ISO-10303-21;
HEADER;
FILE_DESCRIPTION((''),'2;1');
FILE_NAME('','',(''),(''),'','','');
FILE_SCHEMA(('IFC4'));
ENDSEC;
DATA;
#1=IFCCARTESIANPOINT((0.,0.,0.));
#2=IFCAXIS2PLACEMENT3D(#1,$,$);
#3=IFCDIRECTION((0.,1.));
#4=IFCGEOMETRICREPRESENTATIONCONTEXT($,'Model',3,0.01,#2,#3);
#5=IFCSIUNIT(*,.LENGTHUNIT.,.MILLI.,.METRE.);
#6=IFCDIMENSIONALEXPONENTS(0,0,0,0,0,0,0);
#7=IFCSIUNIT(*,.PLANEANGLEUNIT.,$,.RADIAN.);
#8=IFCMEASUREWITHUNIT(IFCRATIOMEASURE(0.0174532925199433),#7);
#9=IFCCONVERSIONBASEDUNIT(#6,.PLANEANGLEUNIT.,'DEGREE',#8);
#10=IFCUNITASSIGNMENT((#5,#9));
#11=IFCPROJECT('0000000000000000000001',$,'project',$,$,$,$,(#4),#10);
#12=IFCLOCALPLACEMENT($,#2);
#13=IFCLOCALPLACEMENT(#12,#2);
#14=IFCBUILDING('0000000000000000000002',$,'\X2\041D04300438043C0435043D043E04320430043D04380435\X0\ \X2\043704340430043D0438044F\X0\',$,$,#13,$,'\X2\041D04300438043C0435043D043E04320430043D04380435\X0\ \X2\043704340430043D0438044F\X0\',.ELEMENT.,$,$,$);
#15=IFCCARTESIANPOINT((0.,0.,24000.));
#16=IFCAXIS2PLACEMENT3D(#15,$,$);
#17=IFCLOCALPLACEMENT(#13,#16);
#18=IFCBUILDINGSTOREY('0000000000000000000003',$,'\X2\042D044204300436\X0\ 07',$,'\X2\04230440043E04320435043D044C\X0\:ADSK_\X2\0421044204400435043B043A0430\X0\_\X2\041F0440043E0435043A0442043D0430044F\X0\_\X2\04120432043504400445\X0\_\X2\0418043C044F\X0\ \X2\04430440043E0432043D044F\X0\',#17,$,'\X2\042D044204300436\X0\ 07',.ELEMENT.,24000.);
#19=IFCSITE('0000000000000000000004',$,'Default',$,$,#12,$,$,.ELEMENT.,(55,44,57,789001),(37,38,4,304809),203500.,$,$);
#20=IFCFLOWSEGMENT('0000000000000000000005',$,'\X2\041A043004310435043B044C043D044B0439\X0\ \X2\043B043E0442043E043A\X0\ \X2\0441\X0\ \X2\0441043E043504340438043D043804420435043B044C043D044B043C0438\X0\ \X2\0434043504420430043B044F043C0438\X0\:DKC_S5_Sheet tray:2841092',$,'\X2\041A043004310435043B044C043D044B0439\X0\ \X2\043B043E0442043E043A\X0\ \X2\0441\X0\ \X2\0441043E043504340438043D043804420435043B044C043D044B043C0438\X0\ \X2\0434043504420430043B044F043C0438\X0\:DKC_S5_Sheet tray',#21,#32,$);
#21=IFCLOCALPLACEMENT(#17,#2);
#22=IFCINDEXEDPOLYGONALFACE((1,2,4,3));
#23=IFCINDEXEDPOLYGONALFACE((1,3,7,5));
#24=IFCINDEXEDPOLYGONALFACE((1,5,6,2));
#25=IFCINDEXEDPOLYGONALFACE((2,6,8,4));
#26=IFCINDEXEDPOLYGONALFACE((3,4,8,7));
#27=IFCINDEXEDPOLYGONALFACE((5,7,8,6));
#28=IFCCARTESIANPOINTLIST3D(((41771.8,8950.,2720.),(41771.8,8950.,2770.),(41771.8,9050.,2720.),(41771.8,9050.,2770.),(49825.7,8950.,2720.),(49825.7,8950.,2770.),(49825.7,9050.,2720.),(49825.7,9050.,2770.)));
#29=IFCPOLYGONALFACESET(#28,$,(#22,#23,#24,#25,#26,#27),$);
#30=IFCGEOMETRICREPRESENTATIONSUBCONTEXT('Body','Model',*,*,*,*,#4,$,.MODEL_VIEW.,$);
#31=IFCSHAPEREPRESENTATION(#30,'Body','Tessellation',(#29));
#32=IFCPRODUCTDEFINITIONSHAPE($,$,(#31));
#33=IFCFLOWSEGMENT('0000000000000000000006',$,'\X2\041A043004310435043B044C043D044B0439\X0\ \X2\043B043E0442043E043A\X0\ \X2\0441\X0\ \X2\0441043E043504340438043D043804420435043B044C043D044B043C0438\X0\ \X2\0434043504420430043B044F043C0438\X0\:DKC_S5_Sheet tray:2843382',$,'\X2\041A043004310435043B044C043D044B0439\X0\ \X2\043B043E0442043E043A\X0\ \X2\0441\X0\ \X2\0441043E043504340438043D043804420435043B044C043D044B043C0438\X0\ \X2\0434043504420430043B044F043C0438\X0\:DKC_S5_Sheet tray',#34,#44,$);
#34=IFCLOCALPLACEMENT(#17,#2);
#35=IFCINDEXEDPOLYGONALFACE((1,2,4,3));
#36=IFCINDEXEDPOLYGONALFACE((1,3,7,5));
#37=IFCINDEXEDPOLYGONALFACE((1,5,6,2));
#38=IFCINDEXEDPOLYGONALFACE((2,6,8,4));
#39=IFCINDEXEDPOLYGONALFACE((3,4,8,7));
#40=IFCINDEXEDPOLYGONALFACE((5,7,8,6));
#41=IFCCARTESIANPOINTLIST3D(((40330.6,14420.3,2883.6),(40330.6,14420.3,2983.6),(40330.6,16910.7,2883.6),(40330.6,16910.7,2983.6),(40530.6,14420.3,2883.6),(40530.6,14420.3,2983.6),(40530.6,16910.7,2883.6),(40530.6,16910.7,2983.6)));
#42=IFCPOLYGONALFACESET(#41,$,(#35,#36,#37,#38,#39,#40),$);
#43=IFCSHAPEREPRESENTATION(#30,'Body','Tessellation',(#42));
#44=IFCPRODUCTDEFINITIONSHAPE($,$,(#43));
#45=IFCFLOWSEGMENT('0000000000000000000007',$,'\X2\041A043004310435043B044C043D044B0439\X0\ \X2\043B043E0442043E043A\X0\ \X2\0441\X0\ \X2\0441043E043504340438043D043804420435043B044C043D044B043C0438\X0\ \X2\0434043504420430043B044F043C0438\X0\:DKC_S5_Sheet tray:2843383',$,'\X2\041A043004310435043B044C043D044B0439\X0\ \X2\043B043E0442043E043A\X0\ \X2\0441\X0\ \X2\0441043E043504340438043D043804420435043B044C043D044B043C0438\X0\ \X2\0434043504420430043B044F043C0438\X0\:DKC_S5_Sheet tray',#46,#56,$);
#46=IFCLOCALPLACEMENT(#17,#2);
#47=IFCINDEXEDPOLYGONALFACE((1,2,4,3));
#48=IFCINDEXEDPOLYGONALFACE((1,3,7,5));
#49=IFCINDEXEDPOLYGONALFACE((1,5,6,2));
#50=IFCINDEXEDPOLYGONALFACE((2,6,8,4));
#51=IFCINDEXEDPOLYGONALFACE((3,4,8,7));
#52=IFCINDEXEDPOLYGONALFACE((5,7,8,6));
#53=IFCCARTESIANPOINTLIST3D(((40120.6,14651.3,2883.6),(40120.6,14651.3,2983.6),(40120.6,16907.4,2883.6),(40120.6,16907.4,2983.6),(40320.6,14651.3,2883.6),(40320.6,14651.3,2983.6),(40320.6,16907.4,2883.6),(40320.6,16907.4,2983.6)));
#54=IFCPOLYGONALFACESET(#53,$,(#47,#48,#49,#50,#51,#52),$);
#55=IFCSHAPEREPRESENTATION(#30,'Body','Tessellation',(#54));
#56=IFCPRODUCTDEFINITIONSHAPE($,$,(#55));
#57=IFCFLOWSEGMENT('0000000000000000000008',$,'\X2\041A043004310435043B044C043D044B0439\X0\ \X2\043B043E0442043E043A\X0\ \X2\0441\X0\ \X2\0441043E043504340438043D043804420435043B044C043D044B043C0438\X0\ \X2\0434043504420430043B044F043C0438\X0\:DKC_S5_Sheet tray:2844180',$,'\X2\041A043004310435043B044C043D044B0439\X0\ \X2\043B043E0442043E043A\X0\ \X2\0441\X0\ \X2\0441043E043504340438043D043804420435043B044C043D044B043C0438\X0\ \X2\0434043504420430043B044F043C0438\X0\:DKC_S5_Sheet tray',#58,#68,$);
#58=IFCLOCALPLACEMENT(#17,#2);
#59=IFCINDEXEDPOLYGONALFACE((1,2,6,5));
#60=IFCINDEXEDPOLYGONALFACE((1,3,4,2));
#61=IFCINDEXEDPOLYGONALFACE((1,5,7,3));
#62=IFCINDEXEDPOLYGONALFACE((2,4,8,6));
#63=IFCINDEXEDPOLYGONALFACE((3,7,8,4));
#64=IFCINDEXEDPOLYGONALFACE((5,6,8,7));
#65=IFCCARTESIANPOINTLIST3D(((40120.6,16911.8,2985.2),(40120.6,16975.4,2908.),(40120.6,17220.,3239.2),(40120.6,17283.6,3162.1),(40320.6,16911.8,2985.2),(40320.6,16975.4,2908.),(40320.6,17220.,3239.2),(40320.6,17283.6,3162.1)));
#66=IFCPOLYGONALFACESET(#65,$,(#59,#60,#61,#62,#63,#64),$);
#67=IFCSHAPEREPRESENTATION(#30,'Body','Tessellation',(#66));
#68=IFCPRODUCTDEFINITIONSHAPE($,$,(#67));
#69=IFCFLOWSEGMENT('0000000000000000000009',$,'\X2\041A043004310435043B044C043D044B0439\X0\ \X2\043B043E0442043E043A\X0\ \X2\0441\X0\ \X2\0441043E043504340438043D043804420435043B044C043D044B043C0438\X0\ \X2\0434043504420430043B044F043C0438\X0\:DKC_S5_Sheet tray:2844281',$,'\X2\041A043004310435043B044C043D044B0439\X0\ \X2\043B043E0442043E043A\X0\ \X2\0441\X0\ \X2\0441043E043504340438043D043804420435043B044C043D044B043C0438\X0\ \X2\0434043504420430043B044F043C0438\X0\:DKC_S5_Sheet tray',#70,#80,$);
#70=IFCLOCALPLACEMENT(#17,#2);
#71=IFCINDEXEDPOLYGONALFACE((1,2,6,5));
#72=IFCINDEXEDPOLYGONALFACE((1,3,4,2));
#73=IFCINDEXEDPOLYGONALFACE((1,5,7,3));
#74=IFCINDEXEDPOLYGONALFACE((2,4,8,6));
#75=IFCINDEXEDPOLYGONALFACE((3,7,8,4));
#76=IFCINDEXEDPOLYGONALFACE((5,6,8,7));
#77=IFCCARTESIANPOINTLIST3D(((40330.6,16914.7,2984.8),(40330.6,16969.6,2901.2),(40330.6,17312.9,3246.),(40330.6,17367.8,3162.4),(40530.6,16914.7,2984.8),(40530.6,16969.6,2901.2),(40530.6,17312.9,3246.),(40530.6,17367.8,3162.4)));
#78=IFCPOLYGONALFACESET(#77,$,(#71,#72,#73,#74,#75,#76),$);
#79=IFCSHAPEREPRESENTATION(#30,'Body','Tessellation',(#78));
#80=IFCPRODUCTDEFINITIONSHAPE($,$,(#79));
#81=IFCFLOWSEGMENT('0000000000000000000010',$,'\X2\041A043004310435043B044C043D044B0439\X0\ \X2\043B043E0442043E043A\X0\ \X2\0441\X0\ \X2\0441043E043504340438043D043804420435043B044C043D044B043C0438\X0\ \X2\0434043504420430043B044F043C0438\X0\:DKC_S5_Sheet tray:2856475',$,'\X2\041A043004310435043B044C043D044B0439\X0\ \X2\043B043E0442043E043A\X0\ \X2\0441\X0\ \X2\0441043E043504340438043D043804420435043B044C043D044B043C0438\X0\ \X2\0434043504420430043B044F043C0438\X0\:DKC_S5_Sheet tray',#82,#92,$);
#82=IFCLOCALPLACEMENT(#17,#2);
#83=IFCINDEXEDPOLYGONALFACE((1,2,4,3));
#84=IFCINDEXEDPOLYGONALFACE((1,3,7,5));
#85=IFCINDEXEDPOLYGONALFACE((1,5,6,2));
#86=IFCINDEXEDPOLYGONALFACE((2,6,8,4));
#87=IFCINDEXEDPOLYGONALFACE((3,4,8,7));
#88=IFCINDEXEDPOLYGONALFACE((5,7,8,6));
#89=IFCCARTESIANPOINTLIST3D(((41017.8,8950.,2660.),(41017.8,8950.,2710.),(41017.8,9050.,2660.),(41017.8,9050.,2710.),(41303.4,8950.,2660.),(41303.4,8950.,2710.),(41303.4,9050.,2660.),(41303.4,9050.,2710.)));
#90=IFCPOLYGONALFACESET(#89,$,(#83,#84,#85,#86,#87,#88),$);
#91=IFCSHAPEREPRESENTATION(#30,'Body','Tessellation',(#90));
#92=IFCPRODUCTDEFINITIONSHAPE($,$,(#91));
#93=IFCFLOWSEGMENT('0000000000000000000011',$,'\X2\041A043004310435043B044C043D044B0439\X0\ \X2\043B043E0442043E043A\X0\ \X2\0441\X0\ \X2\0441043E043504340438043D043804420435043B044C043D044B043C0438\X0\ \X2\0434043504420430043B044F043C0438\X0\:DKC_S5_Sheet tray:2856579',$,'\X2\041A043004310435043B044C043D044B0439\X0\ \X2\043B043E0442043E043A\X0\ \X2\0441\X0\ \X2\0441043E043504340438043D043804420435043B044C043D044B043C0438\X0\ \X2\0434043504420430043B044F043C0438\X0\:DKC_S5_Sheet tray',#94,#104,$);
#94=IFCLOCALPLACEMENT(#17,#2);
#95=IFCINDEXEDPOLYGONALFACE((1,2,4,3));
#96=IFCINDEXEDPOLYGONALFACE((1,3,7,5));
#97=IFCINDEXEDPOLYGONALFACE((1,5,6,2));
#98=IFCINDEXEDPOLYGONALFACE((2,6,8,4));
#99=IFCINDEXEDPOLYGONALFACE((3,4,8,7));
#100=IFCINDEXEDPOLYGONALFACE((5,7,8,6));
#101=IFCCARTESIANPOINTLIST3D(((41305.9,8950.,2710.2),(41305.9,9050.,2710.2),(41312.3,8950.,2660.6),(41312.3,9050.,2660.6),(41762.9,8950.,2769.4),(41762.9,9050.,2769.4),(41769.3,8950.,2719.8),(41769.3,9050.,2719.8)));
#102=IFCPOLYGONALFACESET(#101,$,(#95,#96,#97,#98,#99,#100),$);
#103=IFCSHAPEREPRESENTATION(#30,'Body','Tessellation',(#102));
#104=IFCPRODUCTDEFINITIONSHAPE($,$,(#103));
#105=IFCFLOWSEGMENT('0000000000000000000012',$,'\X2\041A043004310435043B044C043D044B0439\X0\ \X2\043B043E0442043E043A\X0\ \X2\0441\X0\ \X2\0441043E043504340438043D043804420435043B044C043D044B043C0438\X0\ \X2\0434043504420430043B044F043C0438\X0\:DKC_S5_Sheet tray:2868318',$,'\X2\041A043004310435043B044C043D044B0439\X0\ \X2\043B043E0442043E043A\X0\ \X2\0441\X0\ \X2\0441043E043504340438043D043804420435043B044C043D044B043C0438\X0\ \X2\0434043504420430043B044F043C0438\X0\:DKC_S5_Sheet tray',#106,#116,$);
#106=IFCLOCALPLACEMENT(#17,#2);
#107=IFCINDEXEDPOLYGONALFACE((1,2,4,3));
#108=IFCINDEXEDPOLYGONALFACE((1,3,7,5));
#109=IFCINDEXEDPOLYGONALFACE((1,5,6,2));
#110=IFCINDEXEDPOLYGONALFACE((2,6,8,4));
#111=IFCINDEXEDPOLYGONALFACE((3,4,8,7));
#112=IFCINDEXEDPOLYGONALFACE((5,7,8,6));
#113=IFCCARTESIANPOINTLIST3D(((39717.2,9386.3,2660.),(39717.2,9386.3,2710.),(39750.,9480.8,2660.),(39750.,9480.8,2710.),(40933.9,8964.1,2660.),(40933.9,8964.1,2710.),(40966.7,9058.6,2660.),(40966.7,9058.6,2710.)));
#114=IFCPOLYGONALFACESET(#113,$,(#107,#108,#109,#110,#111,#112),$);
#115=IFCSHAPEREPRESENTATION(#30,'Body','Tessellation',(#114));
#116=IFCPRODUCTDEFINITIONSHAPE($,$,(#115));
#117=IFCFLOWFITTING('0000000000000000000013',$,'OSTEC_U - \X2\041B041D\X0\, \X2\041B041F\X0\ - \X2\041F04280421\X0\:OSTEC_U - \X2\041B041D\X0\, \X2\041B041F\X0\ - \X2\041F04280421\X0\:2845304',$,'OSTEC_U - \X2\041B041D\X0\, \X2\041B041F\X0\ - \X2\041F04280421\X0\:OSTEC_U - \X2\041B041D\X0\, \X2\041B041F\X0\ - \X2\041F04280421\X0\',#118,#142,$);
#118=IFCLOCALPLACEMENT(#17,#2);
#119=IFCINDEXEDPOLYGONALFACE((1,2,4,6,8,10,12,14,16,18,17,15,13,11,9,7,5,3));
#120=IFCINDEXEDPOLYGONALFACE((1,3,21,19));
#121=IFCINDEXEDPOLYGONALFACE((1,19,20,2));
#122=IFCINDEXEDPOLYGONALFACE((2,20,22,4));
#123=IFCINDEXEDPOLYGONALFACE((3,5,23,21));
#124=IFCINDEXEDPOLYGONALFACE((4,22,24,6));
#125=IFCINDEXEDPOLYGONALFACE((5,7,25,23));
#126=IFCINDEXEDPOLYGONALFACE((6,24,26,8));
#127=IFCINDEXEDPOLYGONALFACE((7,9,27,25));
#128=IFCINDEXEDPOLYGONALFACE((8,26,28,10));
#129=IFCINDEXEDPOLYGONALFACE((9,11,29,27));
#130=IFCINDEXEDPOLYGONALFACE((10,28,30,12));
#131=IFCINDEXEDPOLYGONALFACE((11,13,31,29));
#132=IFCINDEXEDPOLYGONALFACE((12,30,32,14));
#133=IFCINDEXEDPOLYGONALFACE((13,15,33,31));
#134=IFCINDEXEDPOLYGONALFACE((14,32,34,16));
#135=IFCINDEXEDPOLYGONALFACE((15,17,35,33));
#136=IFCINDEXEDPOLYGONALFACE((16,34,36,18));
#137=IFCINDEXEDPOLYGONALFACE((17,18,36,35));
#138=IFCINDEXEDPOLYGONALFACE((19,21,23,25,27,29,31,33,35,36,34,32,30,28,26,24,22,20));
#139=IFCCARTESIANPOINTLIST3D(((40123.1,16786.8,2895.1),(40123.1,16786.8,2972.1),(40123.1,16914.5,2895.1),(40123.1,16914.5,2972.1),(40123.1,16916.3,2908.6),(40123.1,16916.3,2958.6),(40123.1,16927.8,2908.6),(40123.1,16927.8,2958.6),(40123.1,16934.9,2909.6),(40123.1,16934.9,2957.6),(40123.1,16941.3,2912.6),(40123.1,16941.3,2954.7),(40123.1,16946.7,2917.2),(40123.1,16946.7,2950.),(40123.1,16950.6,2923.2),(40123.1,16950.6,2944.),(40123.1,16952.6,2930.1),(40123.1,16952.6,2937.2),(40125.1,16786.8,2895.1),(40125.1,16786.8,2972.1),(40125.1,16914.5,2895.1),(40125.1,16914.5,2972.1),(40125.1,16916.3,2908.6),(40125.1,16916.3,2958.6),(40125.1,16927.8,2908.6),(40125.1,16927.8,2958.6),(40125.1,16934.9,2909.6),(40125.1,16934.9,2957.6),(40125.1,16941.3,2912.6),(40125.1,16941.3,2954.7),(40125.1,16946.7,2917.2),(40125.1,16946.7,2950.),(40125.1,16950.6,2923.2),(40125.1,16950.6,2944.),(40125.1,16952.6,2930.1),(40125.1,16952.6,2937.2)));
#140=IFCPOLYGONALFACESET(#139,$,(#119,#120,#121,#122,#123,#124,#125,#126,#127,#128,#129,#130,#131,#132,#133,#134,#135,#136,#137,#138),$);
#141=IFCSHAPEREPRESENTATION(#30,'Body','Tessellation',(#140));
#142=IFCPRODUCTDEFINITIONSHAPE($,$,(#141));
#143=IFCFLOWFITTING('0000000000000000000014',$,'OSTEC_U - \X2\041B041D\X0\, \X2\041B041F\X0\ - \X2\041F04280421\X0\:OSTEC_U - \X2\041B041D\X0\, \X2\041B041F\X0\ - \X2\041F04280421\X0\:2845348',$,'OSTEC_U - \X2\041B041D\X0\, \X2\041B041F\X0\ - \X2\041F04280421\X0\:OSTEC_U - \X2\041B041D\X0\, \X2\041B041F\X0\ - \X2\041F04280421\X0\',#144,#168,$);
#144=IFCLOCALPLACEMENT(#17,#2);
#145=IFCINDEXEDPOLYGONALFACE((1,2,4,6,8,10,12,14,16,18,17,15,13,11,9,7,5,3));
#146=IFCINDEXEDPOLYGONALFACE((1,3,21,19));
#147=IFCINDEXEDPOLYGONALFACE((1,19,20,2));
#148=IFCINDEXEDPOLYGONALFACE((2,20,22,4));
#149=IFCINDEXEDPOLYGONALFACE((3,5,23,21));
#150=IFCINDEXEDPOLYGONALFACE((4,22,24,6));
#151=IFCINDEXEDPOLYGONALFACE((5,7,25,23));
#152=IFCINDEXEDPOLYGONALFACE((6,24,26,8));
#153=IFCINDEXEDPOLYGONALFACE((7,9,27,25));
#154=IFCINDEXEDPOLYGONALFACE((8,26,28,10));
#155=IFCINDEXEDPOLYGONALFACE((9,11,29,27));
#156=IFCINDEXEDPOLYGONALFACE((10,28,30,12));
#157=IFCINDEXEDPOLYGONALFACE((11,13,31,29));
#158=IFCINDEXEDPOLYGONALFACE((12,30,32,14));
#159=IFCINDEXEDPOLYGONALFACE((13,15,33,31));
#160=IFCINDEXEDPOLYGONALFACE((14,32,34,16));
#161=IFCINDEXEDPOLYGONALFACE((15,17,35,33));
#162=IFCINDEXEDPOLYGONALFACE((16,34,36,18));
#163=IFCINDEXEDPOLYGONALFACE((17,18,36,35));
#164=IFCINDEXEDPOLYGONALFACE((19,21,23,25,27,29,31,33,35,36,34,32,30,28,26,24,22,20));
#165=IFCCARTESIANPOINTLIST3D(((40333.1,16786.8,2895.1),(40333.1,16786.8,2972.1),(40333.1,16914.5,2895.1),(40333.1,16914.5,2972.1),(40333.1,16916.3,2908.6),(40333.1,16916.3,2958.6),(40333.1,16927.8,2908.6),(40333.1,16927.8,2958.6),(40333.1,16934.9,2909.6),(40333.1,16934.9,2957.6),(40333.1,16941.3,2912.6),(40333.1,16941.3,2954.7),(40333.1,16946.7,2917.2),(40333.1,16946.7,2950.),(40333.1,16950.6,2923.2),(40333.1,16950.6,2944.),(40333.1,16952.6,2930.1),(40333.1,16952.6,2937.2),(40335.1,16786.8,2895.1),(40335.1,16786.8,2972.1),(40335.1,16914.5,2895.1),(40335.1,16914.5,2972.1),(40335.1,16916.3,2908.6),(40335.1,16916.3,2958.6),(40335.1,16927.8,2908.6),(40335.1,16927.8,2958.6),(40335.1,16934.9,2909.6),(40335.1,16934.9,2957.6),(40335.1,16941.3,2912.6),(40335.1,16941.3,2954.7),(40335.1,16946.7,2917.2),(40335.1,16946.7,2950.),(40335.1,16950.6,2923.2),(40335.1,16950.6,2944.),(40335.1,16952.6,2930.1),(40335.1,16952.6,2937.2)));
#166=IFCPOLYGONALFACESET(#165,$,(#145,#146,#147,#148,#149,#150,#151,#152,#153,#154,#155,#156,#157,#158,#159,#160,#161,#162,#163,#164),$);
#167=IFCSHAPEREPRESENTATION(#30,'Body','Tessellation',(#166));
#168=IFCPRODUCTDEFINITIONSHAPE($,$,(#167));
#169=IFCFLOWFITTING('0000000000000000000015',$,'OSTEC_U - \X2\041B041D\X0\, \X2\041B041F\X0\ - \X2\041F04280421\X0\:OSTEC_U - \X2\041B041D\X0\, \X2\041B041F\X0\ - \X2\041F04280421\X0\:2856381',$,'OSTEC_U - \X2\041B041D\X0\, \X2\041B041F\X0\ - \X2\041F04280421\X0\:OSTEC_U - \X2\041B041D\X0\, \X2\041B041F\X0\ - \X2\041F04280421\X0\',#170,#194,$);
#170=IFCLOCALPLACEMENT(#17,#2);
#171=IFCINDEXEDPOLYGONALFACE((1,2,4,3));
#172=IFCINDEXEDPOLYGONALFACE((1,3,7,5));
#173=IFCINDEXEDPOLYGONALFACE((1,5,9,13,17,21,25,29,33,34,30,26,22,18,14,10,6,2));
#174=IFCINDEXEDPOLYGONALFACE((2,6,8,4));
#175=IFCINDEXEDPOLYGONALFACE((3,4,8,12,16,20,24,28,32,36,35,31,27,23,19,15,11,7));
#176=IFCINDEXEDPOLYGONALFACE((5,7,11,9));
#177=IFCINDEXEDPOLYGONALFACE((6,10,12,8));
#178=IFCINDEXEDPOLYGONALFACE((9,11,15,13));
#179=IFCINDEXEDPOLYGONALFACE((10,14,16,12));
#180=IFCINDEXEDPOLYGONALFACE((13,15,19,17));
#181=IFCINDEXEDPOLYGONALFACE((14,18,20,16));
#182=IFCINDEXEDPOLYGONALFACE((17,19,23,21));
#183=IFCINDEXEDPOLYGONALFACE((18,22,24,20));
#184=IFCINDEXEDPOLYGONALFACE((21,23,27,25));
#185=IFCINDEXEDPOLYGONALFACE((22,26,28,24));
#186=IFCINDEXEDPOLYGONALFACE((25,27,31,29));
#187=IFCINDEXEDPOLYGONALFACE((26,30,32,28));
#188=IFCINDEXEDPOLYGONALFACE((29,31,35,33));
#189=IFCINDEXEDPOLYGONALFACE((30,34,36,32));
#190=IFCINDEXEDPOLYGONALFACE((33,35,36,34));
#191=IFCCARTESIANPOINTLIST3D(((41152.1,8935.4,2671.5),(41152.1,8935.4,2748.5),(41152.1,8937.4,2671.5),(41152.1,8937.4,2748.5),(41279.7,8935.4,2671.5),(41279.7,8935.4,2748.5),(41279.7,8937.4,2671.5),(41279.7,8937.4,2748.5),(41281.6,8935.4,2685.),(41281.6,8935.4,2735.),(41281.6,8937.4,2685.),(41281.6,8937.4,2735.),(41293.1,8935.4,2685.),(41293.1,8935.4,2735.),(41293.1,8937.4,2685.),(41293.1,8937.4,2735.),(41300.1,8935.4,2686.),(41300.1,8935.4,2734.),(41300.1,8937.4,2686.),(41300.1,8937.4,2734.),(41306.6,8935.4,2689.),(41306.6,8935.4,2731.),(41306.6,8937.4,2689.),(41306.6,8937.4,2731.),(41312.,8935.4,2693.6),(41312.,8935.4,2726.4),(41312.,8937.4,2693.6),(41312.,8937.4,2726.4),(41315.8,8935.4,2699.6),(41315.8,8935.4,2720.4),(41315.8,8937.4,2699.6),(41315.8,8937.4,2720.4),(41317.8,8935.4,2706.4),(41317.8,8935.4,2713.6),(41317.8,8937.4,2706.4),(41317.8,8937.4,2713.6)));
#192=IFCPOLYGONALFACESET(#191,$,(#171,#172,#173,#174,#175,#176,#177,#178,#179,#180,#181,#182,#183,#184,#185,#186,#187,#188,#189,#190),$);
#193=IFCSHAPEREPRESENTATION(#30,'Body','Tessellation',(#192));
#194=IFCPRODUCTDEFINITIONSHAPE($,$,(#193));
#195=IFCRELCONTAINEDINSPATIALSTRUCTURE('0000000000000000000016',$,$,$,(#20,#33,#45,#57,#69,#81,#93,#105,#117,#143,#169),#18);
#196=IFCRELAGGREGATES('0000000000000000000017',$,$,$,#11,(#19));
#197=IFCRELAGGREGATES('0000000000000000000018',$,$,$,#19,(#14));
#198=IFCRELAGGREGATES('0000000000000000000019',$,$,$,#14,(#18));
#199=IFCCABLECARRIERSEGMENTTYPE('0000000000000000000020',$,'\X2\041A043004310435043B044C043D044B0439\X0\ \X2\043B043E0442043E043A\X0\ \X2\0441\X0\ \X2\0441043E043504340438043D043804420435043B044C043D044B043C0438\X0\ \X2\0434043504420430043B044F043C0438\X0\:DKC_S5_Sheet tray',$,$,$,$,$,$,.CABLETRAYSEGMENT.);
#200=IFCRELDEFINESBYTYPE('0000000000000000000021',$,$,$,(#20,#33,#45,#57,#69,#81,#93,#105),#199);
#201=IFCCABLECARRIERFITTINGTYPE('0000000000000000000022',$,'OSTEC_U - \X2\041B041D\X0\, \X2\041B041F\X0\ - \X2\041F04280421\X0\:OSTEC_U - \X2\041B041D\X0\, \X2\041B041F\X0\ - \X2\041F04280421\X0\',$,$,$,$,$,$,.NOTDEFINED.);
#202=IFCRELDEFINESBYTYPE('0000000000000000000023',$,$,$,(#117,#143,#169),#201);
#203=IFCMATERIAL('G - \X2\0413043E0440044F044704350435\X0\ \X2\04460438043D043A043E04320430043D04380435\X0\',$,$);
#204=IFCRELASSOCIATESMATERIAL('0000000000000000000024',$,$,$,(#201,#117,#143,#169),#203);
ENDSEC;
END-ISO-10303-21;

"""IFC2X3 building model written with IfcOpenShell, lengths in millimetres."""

from ifc_helpers import new_model, entity, si_unit, converted_unit, direction, frame, frame_2d, origin, place, context, subcontext, project, spatial, polyline, circle_curve, parameter, trimmed, segment, composite_curve, rectangle, outline, extrude, source, transform, mapped, material, type_object, type_shapes, element, save


model = new_model("IFC2X3")

# Units and contexts
model_context = context("Model", 3, precision=0.01, world=origin(), true_north=direction((0.0, 1.0)))
body_context = subcontext(model_context, "Body", "Model", "MODEL_VIEW")
ifc_project = project(units=[si_unit("LENGTHUNIT", "METRE", prefix="MILLI"), converted_unit("PLANEANGLEUNIT", "DEGREE", entity("IfcRatioMeasure", 0.0174532925199433), si_unit("PLANEANGLEUNIT", "RADIAN"), dimensions=[0, 0, 0, 0, 0, 0, 0])], contexts=[model_context])

# Site, building, storey
site_placement = place(None, frame((0.0, 0.0, 0.0)))
site = spatial("IfcSite", under=ifc_project, at=site_placement, Name="Default", CompositionType="ELEMENT", RefLatitude=(55, 44, 57, 789001), RefLongitude=(37, 38, 4, 304809), RefElevation=203500.0)
building_placement = place(site_placement, origin())
building = spatial("IfcBuilding", under=site, at=building_placement, Name="Наименование здания", LongName="Наименование здания", CompositionType="ELEMENT")
storey_placement = place(building_placement, frame((0.0, 0.0, 24000.0)))
storey = spatial("IfcBuildingStorey", under=building, at=storey_placement, Name="Этаж 07", ObjectType="Уровень:ADSK_Стрелка_Проектная_Вверх_Имя уровня", LongName="Этаж 07", CompositionType="ELEMENT", Elevation=24000.0)

# Flow segments
cable_carrier_segment_type = type_object("IfcCableCarrierSegmentType", Name="Кабельный лоток с соединительными деталями:DKC_S5_Sheet tray", PredefinedType="CABLETRAYSEGMENT")
flow_segment_1_placement = place(storey_placement, frame((41771.8, 8950.0, 2720.0)))
element("IfcFlowSegment", 1, at=flow_segment_1_placement, inside=storey, type_object=cable_carrier_segment_type, Name="Кабельный лоток с соединительными деталями:DKC_S5_Sheet tray:2841092", ObjectType="Кабельный лоток с соединительными деталями:DKC_S5_Sheet tray", context=body_context, shape_type="SweptSolid", body=[
    extrude(rectangle(XDim=8053.8, YDim=100.0, at=frame_2d((0.0, 0.0), x_axis=(1.0, 0.0))), frame((4026.9, 50.0, 0.0), z_axis=(0.0, 0.0, 1.0), x_axis=(-1.0, 0.0, 0.0)), (0.0, 0.0, 1.0), 50.0),
])
flow_segment_2_placement = place(storey_placement, frame((40330.6, 14420.3, 2883.6)))
element("IfcFlowSegment", 2, at=flow_segment_2_placement, inside=storey, type_object=cable_carrier_segment_type, Name="Кабельный лоток с соединительными деталями:DKC_S5_Sheet tray:2843382", ObjectType="Кабельный лоток с соединительными деталями:DKC_S5_Sheet tray", context=body_context, shape_type="SweptSolid", body=[
    extrude(rectangle(XDim=2490.4, YDim=200.0, at=frame_2d((0.0, 0.0), x_axis=(1.0, 0.0))), frame((100.0, 1245.2, 0.0), z_axis=(0.0, 0.0, 1.0), x_axis=(0.0, -1.0, 0.0)), (0.0, 0.0, 1.0), 100.0),
])
flow_segment_3_placement = place(storey_placement, frame((40120.6, 14651.3, 2883.6)))
element("IfcFlowSegment", 3, at=flow_segment_3_placement, inside=storey, type_object=cable_carrier_segment_type, Name="Кабельный лоток с соединительными деталями:DKC_S5_Sheet tray:2843383", ObjectType="Кабельный лоток с соединительными деталями:DKC_S5_Sheet tray", context=body_context, shape_type="SweptSolid", body=[
    extrude(rectangle(XDim=2256.1, YDim=200.0, at=frame_2d((0.0, 0.0), x_axis=(1.0, 0.0))), frame((100.0, 1128.1, 0.0), z_axis=(0.0, 0.0, 1.0), x_axis=(0.0, -1.0, 0.0)), (0.0, 0.0, 1.0), 100.0),
])
flow_segment_4_placement = place(storey_placement, frame((40120.6, 16911.8, 2908.0)))
element("IfcFlowSegment", 4, at=flow_segment_4_placement, inside=storey, type_object=cable_carrier_segment_type, Name="Кабельный лоток с соединительными деталями:DKC_S5_Sheet tray:2844180", ObjectType="Кабельный лоток с соединительными деталями:DKC_S5_Sheet tray", context=body_context, shape_type="SweptSolid", body=[
    extrude(rectangle(XDim=100.0, YDim=399.5, at=frame_2d((0.0, 0.0), x_axis=(0.0, 1.0))), frame((0.0, 185.9, 165.6), z_axis=(1.0, 0.0, 0.0), x_axis=(0.0, 0.771695, 0.635992)), (0.0, 0.0, 1.0), 200.0),
])
flow_segment_5_placement = place(storey_placement, frame((40330.6, 16914.7, 2901.2)))
element("IfcFlowSegment", 5, at=flow_segment_5_placement, inside=storey, type_object=cable_carrier_segment_type, Name="Кабельный лоток с соединительными деталями:DKC_S5_Sheet tray:2844281", ObjectType="Кабельный лоток с соединительными деталями:DKC_S5_Sheet tray", context=body_context, shape_type="SweptSolid", body=[
    extrude(rectangle(XDim=100.0, YDim=476.2, at=frame_2d((0.0, 0.0), x_axis=(0.0, 1.0))), frame((0.0, 226.5, 172.4), z_axis=(1.0, 0.0, 0.0), x_axis=(0.0, 0.836155, 0.548493)), (0.0, 0.0, 1.0), 200.0),
])
flow_segment_6_placement = place(storey_placement, frame((41017.8, 8950.0, 2660.0)))
element("IfcFlowSegment", 6, at=flow_segment_6_placement, inside=storey, type_object=cable_carrier_segment_type, Name="Кабельный лоток с соединительными деталями:DKC_S5_Sheet tray:2856475", ObjectType="Кабельный лоток с соединительными деталями:DKC_S5_Sheet tray", context=body_context, shape_type="SweptSolid", body=[
    extrude(rectangle(XDim=285.6, YDim=100.0, at=frame_2d((0.0, 0.0), x_axis=(1.0, 0.0))), frame((142.8, 50.0, 0.0), z_axis=(0.0, 0.0, 1.0), x_axis=(-1.0, 0.0, 0.0)), (0.0, 0.0, 1.0), 50.0),
])
flow_segment_7_placement = place(storey_placement, frame((41305.9, 8950.0, 2660.6)))
element("IfcFlowSegment", 7, at=flow_segment_7_placement, inside=storey, type_object=cable_carrier_segment_type, Name="Кабельный лоток с соединительными деталями:DKC_S5_Sheet tray:2856579", ObjectType="Кабельный лоток с соединительными деталями:DKC_S5_Sheet tray", context=body_context, shape_type="SweptSolid", body=[
    extrude(rectangle(XDim=50.0, YDim=100.0, at=frame_2d((0.0, 0.0), x_axis=(0.0, 1.0))), frame((3.2, 50.0, 24.8), z_axis=(0.991697, 0.0, 0.128594), x_axis=(0.0, 1.0, 0.0)), (0.0, 0.0, 1.0), 460.8),
])
flow_segment_8_placement = place(storey_placement, frame((39717.2, 8964.1, 2660.0)))
element("IfcFlowSegment", 8, at=flow_segment_8_placement, inside=storey, type_object=cable_carrier_segment_type, Name="Кабельный лоток с соединительными деталями:DKC_S5_Sheet tray:2868318", ObjectType="Кабельный лоток с соединительными деталями:DKC_S5_Sheet tray", context=body_context, shape_type="SweptSolid", body=[
    extrude(rectangle(XDim=1287.8, YDim=100.0, at=frame_2d((0.0, 0.0), x_axis=(1.0, 0.0))), frame((624.7, 258.3, 0.0), z_axis=(0.0, 0.0, 1.0), x_axis=(-0.944738, 0.327828, 0.0)), (0.0, 0.0, 1.0), 50.0),
])

# Flow fittings
ifc_material_1 = material(Name="G - Горячее цинкование")
cable_carrier_fitting_type_1 = type_object("IfcCableCarrierFittingType", Name="OSTEC_U - ЛН, ЛП - ПШС:OSTEC_U - ЛН, ЛП - ПШС", PredefinedType="NOTDEFINED", material=ifc_material_1)
shared_shape_1 = source(origin(), body_context, "Body", "SweptSolid", [
    extrude(outline(composite_curve([segment(trimmed(circle_curve(frame_2d((-41.5, 0.0), x_axis=(1.0, 0.0)), 25.0), [parameter(90.0)], [parameter(270.0)], True, "PARAMETER"), True, "CONTINUOUS"), segment(polyline([(-41.5, -25.0), (-30.0, -25.0)]), True, "CONTINUOUS"), segment(polyline([(-30.0, -25.0), (-28.1, -38.5)]), True, "CONTINUOUS"), segment(polyline([(-28.1, -38.5), (99.5, -38.5)]), True, "CONTINUOUS"), segment(polyline([(99.5, -38.5), (99.5, 38.5)]), True, "CONTINUOUS"), segment(polyline([(99.5, 38.5), (-28.1, 38.5)]), True, "CONTINUOUS"), segment(polyline([(-28.1, 38.5), (-30.0, 25.0)]), True, "CONTINUOUS"), segment(polyline([(-30.0, 25.0), (-41.5, 25.0)]), True, "CONTINUOUS")], self_intersect=False)), frame((41.5, 0.0, 0.0), z_axis=(0.0, 0.0, -1.0), x_axis=(1.0, 0.0, 0.0)), (0.0, 0.0, -1.0), 2.0),
])
type_shapes(cable_carrier_fitting_type_1, [shared_shape_1])
for number, where, z_axis, x_axis, name in (
    (9, (40125.1, 16927.8, 2933.6), (-1.0, 0.0, 0.0), (0.0, -1.0, 0.0), "OSTEC_U - ЛН, ЛП - ПШС:OSTEC_U - ЛН, ЛП - ПШС:2845304"),
    (10, (40335.1, 16927.8, 2933.6), (-1.0, 0.0, 0.0), (0.0, -1.0, 0.0), "OSTEC_U - ЛН, ЛП - ПШС:OSTEC_U - ЛН, ЛП - ПШС:2845348"),
    (11, (41293.1, 8935.4, 2710.0), (0.0, 1.0, 0.0), (-1.0, 0.0, 0.0), "OSTEC_U - ЛН, ЛП - ПШС:OSTEC_U - ЛН, ЛП - ПШС:2856381"),
):
    element("IfcFlowFitting", number, at=place(storey_placement, frame(where, z_axis=z_axis, x_axis=x_axis)), inside=storey, type_object=cable_carrier_fitting_type_1, material=ifc_material_1, Name=name, ObjectType="OSTEC_U - ЛН, ЛП - ПШС:OSTEC_U - ЛН, ЛП - ПШС", context=body_context, shape_type="MappedRepresentation", body=[
        mapped(shared_shape_1, transform((0.0, 0.0, 0.0), scale=1.0)),
    ])

save(model, "model.ifc")
